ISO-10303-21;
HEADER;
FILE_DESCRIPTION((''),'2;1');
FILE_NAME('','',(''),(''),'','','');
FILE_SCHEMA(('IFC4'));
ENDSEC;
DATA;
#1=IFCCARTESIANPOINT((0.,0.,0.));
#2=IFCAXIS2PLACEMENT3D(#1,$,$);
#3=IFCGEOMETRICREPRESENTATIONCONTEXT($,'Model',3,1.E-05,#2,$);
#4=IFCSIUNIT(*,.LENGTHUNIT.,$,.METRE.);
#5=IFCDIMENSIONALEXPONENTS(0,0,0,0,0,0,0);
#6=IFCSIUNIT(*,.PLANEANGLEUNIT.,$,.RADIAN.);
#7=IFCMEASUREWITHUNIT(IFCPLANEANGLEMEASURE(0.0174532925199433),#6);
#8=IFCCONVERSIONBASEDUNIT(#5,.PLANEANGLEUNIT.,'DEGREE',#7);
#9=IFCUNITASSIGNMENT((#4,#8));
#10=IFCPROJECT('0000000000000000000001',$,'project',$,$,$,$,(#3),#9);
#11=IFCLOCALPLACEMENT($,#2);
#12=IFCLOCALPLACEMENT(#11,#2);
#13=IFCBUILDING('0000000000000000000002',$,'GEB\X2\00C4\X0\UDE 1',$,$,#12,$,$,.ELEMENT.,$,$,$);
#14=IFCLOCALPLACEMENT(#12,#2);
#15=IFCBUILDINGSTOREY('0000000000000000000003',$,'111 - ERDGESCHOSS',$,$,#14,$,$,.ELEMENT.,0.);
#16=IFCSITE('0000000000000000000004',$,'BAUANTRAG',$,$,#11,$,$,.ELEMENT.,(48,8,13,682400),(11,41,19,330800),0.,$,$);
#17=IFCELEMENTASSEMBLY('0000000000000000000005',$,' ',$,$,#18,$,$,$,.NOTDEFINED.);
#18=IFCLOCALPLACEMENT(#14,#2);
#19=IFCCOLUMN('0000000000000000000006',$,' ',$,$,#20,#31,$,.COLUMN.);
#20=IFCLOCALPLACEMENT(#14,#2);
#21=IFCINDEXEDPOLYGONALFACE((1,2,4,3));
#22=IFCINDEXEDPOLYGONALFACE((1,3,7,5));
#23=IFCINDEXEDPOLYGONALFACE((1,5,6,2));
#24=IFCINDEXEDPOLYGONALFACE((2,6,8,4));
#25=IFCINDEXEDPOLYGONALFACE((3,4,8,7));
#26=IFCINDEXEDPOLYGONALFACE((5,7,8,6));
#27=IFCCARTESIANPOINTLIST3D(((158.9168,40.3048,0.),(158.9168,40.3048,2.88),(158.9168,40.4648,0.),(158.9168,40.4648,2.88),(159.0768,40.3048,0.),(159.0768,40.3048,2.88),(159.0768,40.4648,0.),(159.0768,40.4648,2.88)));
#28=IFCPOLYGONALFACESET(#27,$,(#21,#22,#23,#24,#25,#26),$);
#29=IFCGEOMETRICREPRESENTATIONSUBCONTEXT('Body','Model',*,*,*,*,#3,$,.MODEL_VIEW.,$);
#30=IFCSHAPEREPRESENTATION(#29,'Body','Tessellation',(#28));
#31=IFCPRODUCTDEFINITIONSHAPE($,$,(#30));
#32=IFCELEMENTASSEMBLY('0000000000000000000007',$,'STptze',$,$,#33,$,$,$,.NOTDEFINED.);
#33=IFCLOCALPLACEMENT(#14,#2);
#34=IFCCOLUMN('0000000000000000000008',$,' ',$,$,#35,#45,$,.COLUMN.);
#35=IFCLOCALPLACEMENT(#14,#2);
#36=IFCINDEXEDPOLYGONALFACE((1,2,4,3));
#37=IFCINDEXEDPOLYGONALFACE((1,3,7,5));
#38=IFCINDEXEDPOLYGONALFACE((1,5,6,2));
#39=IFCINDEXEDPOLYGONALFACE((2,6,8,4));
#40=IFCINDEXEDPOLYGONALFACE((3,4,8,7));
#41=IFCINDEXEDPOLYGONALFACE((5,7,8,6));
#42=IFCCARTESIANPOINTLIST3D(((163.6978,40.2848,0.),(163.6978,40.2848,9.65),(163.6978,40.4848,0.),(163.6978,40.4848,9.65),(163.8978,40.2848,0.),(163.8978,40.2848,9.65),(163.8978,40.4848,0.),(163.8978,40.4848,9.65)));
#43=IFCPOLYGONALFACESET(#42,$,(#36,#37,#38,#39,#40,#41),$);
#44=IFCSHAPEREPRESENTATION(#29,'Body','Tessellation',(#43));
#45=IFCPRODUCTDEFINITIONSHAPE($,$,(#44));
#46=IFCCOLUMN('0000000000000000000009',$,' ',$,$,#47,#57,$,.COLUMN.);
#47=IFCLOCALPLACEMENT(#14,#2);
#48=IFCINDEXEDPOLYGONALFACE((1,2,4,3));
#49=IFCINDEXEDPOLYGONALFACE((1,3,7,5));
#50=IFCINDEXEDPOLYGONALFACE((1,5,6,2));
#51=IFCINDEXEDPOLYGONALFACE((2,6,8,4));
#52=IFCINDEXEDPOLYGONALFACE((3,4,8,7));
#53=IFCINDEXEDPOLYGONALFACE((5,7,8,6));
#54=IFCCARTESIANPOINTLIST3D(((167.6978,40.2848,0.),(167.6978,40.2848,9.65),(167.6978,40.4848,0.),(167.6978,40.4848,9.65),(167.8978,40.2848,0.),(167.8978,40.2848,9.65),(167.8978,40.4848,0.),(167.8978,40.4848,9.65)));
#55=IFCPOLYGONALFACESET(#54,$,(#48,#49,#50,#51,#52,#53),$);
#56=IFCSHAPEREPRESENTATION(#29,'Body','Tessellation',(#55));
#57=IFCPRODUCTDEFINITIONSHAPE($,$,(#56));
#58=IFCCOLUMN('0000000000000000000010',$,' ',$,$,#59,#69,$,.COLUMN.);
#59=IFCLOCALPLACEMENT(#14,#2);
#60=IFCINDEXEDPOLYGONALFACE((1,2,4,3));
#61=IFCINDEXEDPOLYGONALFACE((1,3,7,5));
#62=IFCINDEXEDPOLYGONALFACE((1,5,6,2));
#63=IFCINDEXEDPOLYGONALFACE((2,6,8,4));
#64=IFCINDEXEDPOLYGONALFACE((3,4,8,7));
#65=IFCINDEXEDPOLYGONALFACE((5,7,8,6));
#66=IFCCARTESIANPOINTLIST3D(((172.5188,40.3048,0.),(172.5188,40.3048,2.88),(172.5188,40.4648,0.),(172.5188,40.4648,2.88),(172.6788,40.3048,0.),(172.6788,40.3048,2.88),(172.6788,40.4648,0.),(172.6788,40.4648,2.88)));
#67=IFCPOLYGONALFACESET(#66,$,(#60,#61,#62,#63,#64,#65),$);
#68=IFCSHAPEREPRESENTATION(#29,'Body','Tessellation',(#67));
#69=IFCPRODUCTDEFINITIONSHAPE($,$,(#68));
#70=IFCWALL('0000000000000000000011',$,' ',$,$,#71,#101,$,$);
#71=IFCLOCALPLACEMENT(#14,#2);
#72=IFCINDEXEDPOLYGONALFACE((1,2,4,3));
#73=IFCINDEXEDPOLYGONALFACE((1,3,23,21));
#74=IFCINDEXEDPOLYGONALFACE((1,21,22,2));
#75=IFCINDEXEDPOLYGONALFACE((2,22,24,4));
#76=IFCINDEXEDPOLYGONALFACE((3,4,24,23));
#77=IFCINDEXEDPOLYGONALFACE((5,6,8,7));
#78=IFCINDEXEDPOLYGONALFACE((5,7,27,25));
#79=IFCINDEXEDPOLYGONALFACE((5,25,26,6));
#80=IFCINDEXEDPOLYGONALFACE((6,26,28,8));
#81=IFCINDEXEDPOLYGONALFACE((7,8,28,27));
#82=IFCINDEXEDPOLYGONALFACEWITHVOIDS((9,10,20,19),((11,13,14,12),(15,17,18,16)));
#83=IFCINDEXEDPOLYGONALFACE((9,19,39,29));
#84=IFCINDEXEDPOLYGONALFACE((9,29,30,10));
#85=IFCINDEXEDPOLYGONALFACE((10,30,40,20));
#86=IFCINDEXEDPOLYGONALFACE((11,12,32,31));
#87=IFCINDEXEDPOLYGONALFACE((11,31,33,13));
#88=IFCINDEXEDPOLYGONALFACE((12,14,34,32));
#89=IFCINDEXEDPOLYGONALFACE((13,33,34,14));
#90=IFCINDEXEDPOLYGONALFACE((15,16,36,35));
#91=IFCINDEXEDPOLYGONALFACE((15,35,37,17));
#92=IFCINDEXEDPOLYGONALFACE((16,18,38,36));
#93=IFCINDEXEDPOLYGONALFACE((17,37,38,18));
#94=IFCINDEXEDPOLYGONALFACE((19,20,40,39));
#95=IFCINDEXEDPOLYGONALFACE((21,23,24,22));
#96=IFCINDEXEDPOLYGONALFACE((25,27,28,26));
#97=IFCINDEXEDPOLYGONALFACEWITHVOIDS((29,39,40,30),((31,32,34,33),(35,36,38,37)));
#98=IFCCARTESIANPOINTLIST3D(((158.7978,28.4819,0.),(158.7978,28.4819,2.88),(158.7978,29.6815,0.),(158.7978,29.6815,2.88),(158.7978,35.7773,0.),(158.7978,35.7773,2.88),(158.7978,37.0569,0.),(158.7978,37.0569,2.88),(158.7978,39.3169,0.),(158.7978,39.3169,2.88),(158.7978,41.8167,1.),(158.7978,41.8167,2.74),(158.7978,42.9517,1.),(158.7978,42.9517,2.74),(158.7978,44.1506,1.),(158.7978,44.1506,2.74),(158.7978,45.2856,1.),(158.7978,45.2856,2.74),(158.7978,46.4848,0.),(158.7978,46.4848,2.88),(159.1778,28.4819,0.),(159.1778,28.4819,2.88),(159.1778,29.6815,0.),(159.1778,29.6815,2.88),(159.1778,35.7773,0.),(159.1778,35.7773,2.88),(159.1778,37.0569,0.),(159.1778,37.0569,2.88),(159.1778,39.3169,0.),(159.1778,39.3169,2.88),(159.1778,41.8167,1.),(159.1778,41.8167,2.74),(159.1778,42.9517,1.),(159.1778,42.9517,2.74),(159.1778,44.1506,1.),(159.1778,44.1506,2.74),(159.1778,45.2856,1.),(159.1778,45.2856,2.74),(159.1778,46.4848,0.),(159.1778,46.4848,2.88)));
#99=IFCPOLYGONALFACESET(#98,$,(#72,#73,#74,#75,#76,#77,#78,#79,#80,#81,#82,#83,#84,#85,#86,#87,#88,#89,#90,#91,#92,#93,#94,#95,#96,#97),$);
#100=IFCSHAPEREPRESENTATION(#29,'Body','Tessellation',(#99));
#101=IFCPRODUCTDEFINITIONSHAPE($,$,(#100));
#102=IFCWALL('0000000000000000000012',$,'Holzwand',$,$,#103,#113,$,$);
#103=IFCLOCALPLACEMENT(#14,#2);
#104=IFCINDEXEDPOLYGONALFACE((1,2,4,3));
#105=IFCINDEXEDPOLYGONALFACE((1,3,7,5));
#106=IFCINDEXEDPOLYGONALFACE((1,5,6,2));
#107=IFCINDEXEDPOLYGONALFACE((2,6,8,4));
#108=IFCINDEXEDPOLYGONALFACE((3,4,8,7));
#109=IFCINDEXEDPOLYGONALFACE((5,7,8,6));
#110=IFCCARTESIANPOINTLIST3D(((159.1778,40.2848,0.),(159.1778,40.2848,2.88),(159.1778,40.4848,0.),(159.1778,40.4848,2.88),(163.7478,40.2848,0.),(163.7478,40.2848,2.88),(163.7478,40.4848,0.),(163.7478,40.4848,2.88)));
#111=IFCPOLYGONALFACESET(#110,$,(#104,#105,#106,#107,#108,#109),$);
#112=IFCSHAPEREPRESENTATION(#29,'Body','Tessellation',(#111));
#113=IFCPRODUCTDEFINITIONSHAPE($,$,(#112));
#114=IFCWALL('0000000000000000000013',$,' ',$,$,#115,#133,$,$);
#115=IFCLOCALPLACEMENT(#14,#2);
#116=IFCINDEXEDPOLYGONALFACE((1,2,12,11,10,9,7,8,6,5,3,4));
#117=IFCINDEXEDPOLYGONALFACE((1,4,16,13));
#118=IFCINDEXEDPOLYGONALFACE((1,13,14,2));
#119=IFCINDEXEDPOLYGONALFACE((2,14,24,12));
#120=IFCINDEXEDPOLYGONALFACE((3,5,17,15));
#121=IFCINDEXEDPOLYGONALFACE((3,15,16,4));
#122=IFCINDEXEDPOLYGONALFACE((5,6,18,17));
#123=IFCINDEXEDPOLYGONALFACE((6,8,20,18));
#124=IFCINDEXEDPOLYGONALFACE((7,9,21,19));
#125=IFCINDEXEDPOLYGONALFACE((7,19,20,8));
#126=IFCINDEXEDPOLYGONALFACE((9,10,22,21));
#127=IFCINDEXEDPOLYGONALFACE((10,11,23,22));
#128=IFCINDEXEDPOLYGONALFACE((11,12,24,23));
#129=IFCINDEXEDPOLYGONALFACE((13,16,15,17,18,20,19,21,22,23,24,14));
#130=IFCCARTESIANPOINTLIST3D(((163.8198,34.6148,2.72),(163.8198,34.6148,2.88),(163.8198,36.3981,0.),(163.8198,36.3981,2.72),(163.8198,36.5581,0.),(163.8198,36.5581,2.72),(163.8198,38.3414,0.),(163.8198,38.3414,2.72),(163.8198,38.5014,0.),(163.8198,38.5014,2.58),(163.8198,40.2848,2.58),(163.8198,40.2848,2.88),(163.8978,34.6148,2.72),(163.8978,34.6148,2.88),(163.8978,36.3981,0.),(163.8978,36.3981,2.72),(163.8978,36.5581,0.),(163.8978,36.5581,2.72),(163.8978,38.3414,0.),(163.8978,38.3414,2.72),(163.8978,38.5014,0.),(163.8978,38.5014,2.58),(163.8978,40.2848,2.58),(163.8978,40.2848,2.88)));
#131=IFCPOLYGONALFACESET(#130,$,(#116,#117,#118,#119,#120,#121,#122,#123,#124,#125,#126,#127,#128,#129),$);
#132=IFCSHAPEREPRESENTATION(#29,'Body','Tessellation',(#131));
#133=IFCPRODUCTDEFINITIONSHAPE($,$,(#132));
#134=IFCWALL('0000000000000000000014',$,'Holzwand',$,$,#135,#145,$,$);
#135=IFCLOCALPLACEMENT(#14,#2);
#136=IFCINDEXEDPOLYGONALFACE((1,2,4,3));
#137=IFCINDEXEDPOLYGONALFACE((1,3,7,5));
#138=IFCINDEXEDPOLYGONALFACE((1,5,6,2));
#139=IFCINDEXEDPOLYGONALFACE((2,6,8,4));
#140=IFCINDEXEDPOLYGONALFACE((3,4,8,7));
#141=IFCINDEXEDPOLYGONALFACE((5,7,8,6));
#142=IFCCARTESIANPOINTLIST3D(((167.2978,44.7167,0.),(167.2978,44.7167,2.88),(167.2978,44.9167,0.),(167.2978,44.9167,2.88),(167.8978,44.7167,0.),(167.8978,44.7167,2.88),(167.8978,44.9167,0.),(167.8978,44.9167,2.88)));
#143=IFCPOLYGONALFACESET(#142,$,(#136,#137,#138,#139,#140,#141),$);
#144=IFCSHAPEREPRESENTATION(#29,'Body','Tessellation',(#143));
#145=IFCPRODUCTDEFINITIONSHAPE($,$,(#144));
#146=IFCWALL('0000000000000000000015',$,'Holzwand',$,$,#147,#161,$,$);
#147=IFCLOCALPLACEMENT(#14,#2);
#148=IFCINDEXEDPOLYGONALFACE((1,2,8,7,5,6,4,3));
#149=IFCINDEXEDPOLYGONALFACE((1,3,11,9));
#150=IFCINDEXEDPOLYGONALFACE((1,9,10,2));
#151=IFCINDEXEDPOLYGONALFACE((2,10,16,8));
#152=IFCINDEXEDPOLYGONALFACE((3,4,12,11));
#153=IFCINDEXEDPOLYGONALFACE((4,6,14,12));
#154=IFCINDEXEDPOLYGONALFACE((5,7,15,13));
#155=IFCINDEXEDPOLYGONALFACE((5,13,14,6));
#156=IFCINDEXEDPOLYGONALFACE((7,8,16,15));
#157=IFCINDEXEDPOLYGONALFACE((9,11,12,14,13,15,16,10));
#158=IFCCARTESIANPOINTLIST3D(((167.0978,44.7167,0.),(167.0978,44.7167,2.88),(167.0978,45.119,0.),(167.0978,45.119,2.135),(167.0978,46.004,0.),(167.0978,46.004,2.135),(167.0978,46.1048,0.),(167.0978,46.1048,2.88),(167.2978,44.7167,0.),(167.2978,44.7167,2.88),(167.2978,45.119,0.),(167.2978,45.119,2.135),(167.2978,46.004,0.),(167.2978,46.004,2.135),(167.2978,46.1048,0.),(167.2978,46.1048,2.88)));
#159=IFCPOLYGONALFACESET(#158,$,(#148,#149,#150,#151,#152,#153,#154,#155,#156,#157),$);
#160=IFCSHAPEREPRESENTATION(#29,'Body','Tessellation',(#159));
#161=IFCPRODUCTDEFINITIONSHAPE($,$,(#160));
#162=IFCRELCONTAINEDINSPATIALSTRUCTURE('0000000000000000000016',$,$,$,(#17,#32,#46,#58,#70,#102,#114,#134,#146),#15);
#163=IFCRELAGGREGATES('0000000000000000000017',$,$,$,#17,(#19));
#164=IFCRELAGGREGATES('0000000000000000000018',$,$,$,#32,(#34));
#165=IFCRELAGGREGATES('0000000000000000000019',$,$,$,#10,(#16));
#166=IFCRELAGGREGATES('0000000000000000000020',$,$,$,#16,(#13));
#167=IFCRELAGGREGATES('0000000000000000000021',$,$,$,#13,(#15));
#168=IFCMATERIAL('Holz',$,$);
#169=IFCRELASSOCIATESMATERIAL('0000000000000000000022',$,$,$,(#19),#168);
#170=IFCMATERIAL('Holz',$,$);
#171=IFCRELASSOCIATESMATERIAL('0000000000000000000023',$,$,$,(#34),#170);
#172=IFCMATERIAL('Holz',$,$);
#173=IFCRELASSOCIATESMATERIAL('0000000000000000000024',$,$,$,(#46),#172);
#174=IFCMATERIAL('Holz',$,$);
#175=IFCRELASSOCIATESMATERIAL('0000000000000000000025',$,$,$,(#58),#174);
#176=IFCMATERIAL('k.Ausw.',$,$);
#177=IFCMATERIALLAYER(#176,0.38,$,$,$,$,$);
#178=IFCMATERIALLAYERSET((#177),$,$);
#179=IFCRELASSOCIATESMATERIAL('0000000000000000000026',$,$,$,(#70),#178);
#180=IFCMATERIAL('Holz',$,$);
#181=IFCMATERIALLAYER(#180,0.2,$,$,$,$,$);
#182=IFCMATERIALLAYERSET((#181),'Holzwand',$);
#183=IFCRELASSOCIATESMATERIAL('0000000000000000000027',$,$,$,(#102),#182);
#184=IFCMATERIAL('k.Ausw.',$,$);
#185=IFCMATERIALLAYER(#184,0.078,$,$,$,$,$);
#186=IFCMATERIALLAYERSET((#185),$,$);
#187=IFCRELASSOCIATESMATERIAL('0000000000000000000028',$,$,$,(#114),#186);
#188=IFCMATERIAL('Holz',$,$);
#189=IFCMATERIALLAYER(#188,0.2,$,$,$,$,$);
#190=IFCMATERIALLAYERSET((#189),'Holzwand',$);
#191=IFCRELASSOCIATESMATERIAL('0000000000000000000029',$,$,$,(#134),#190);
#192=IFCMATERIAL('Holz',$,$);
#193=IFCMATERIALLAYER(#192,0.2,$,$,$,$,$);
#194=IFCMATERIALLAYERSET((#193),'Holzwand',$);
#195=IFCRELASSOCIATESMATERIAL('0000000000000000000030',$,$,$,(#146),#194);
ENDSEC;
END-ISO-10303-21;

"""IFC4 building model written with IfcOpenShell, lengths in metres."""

from ifc_helpers import new_model, entity, si_unit, converted_unit, frame, frame_2d, origin, origin_with_axes, place, context, subcontext, project, spatial, polyline, rectangle, outline, extrude, material, layer, layer_set, layer_usage, element, aggregate, save


model = new_model("IFC4")

# Units and contexts
model_context = context("Model", 3, precision=1e-05, world=origin())
body_context = subcontext(model_context, "Body", "Model", "MODEL_VIEW")
ifc_project = project(units=[si_unit("LENGTHUNIT", "METRE"), converted_unit("PLANEANGLEUNIT", "DEGREE", entity("IfcPlaneAngleMeasure", 0.0174532925199433), si_unit("PLANEANGLEUNIT", "RADIAN"), dimensions=[0, 0, 0, 0, 0, 0, 0])], contexts=[model_context])

# Site, building, storey
site_placement = place(None, origin())
site = spatial("IfcSite", under=ifc_project, at=site_placement, Name="BAUANTRAG", CompositionType="ELEMENT", RefLatitude=(48, 8, 13, 682400), RefLongitude=(11, 41, 19, 330800), RefElevation=0.0)
building_placement = place(site_placement, origin())
building = spatial("IfcBuilding", under=site, at=building_placement, Name="GEBÄUDE 1", CompositionType="ELEMENT")
storey_placement = place(building_placement, origin())
storey = spatial("IfcBuildingStorey", under=building, at=storey_placement, Name="111 - ERDGESCHOSS", CompositionType="ELEMENT", Elevation=0.0)

# Element assemblies, columns
assembly_1_placement = place(storey_placement, origin())
assembly_1 = element("IfcElementAssembly", 1, at=assembly_1_placement, inside=storey, Name=" ", PredefinedType="NOTDEFINED")
ifc_material_1 = material(Name="Holz")
column_1_placement = place(assembly_1_placement, frame((158.9168, 40.3048, 0.0)))
column_1 = element("IfcColumn", 2, at=column_1_placement, material=ifc_material_1, Name=" ", PredefinedType="COLUMN", context=body_context, shape_type="SweptSolid", body=[
    extrude(rectangle(XDim=0.16, YDim=0.16, at=frame_2d((0.08, 0.08), x_axis=(1.0, 0.0))), origin_with_axes(), (0.0, 0.0, 1.0), 2.88),
])
aggregate(assembly_1, [column_1])
assembly_2_placement = place(storey_placement, origin())
assembly_2 = element("IfcElementAssembly", 3, at=assembly_2_placement, inside=storey, Name="STptze", PredefinedType="NOTDEFINED")
ifc_material_2 = material(Name="Holz")
column_2_placement = place(assembly_2_placement, frame((163.6978, 40.2848, 0.0)))
column_2 = element("IfcColumn", 4, at=column_2_placement, material=ifc_material_2, Name=" ", PredefinedType="COLUMN", context=body_context, shape_type="SweptSolid", body=[
    extrude(rectangle(XDim=0.2, YDim=0.2, at=frame_2d((0.1, 0.1), x_axis=(1.0, 0.0))), origin_with_axes(), (0.0, 0.0, 1.0), 9.65),
])
aggregate(assembly_2, [column_2])

# Columns
ifc_material_3 = material(Name="Holz")
column_3_placement = place(storey_placement, frame((167.6978, 40.2848, 0.0)))
element("IfcColumn", 5, at=column_3_placement, inside=storey, material=ifc_material_3, Name=" ", PredefinedType="COLUMN", context=body_context, shape_type="SweptSolid", body=[
    extrude(rectangle(XDim=0.2, YDim=0.2, at=frame_2d((0.1, 0.1), x_axis=(1.0, 0.0))), origin_with_axes(), (0.0, 0.0, 1.0), 9.65),
])
ifc_material_4 = material(Name="Holz")
column_4_placement = place(storey_placement, frame((172.5188, 40.3048, 0.0)))
element("IfcColumn", 6, at=column_4_placement, inside=storey, material=ifc_material_4, Name=" ", PredefinedType="COLUMN", context=body_context, shape_type="SweptSolid", body=[
    extrude(rectangle(XDim=0.16, YDim=0.16, at=frame_2d((0.08, 0.08), x_axis=(1.0, 0.0))), origin_with_axes(), (0.0, 0.0, 1.0), 2.88),
])

# Wall, openings
ifc_material_5 = material(Name="k.Ausw.")
ifc_layer_1 = layer(ifc_material_5, 0.38)
ifc_layer_set_1 = layer_set([ifc_layer_1])
ifc_layer_usage_1 = layer_usage(ifc_layer_set_1, "AXIS2", "POSITIVE", 0.0)
wall_1_placement = place(storey_placement, frame((158.7978, 46.4848, 0.0), z_axis=(0.0, 0.0, 1.0), x_axis=(0.0, -1.0, 0.0)))
wall_1 = element("IfcWall", 7, at=wall_1_placement, inside=storey, material=ifc_layer_usage_1, Name=" ", context=body_context, shape_type="SweptSolid", body=[
    extrude(rectangle(XDim=18.0029, YDim=0.38, at=frame_2d((9.0014, 0.19), x_axis=(1.0, 0.0))), origin_with_axes(), (0.0, 0.0, 1.0), 2.88),
])
opening_1_placement = place(wall_1_placement, frame((12.0614, 0.0, 0.0), z_axis=(0.0, 1.0, 0.0), x_axis=(0.0, 0.0, 1.0)))
element("IfcOpeningElement", 8, at=opening_1_placement, cuts=wall_1, ObjectType="Opening", context=body_context, shape_type="SweptSolid", body=[
    extrude(outline(polyline([(0.0, 3.608), (2.88, 3.608), (2.88, 0.0), (0.0, 0.0), (0.0, 3.608)])), origin_with_axes(), (0.0, 0.0, 1.0), 0.38),
])
opening_2_placement = place(wall_1_placement, frame((10.7075, 0.0, 0.0), z_axis=(0.0, 1.0, 0.0), x_axis=(0.0, 0.0, 1.0)))
element("IfcOpeningElement", 9, at=opening_2_placement, cuts=wall_1, ObjectType="Opening", context=body_context, shape_type="SweptSolid", body=[
    extrude(outline(polyline([(0.0, 1.3539), (2.88, 1.3539), (2.88, 0.0), (0.0, 0.0), (0.0, 1.3539)])), origin_with_axes(), (0.0, 0.0, 1.0), 0.38),
])
opening_3_placement = place(wall_1_placement, frame((7.1679, 0.0, 0.0), z_axis=(0.0, 1.0, 0.0), x_axis=(0.0, 0.0, 1.0)))
element("IfcOpeningElement", 10, at=opening_3_placement, cuts=wall_1, ObjectType="Opening", context=body_context, shape_type="SweptSolid", body=[
    extrude(outline(polyline([(0.0, 2.26), (2.88, 2.26), (2.88, 0.0), (0.0, 0.0), (0.0, 2.26)])), origin_with_axes(), (0.0, 0.0, 1.0), 0.38),
])
opening_4_placement = place(wall_1_placement, frame((1.1992, 0.0, 1.0), z_axis=(0.0, 1.0, 0.0), x_axis=(0.0, 0.0, 1.0)))
element("IfcOpeningElement", 11, at=opening_4_placement, cuts=wall_1, ObjectType="Opening", context=body_context, shape_type="SweptSolid", body=[
    extrude(outline(polyline([(0.0, 1.135), (1.74, 1.135), (1.74, 0.0), (0.0, 0.0), (0.0, 1.135)])), origin_with_axes(), (0.0, 0.0, 1.0), 0.38),
])
opening_5_placement = place(wall_1_placement, frame((3.5331, 0.0, 1.0), z_axis=(0.0, 1.0, 0.0), x_axis=(0.0, 0.0, 1.0)))
element("IfcOpeningElement", 12, at=opening_5_placement, cuts=wall_1, ObjectType="Opening", context=body_context, shape_type="SweptSolid", body=[
    extrude(outline(polyline([(0.0, 1.135), (1.74, 1.135), (1.74, 0.0), (0.0, 0.0), (0.0, 1.135)])), origin_with_axes(), (0.0, 0.0, 1.0), 0.38),
])
opening_6_placement = place(wall_1_placement, frame((15.6683, 0.0, 0.0), z_axis=(0.0, 1.0, 0.0), x_axis=(0.0, 0.0, 1.0)))
element("IfcOpeningElement", 13, at=opening_6_placement, cuts=wall_1, ObjectType="Opening", context=body_context, shape_type="SweptSolid", body=[
    extrude(outline(polyline([(0.0, 1.135), (2.88, 1.135), (2.88, 0.0), (0.0, 0.0), (0.0, 1.135)])), origin_with_axes(), (0.0, 0.0, 1.0), 0.38),
])

# Wall
ifc_material_6 = material(Name="Holz")
ifc_layer_2 = layer(ifc_material_6, 0.2)
ifc_layer_set_2 = layer_set([ifc_layer_2], Name="Holzwand")
ifc_layer_usage_2 = layer_usage(ifc_layer_set_2, "AXIS2", "POSITIVE", 0.0)
wall_2_placement = place(storey_placement, frame((163.7478, 40.4848, 0.0), z_axis=(0.0, 0.0, 1.0), x_axis=(-1.0, 0.0, 0.0)))
element("IfcWall", 14, at=wall_2_placement, inside=storey, material=ifc_layer_usage_2, Name="Holzwand", context=body_context, shape_type="SweptSolid", body=[
    extrude(rectangle(XDim=4.57, YDim=0.2, at=frame_2d((2.285, 0.1), x_axis=(1.0, 0.0))), origin_with_axes(), (0.0, 0.0, 1.0), 2.88),
])

# Wall, openings
ifc_material_7 = material(Name="k.Ausw.")
ifc_layer_3 = layer(ifc_material_7, 0.078)
ifc_layer_set_3 = layer_set([ifc_layer_3])
ifc_layer_usage_3 = layer_usage(ifc_layer_set_3, "AXIS2", "POSITIVE", 0.0)
wall_3_placement = place(storey_placement, frame((163.8198, 40.2848, 0.0), z_axis=(0.0, 0.0, 1.0), x_axis=(0.0, -1.0, 0.0)))
wall_3 = element("IfcWall", 15, at=wall_3_placement, inside=storey, material=ifc_layer_usage_3, Name=" ", context=body_context, shape_type="SweptSolid", body=[
    extrude(rectangle(XDim=5.67, YDim=0.078, at=frame_2d((2.835, 0.039), x_axis=(1.0, 0.0))), origin_with_axes(), (0.0, 0.0, 1.0), 2.88),
])
opening_7_placement = place(wall_3_placement, frame((1.9434, 0.0, 0.0), z_axis=(0.0, 1.0, 0.0), x_axis=(0.0, 0.0, 1.0)))
element("IfcOpeningElement", 16, at=opening_7_placement, cuts=wall_3, ObjectType="Opening", context=body_context, shape_type="SweptSolid", body=[
    extrude(outline(polyline([(0.0, 1.7833), (2.72, 1.7833), (2.72, 0.0), (0.0, 0.0), (0.0, 1.7833)])), origin_with_axes(), (0.0, 0.0, 1.0), 0.078),
])
opening_8_placement = place(wall_3_placement, frame((3.8867, 0.0, 0.0), z_axis=(0.0, 1.0, 0.0), x_axis=(0.0, 0.0, 1.0)))
element("IfcOpeningElement", 17, at=opening_8_placement, cuts=wall_3, ObjectType="Opening", context=body_context, shape_type="SweptSolid", body=[
    extrude(outline(polyline([(0.0, 1.7833), (2.72, 1.7833), (2.72, 0.0), (0.0, 0.0), (0.0, 1.7833)])), origin_with_axes(), (0.0, 0.0, 1.0), 0.078),
])
opening_9_placement = place(wall_3_placement, frame((0.0, 0.0, -0.14), z_axis=(0.0, 1.0, 0.0), x_axis=(0.0, 0.0, 1.0)))
element("IfcOpeningElement", 18, at=opening_9_placement, cuts=wall_3, ObjectType="Opening", context=body_context, shape_type="SweptSolid", body=[
    extrude(outline(polyline([(0.0, 1.7834), (2.72, 1.7834), (2.72, 0.0), (0.0, 0.0), (0.0, 1.7834)])), origin_with_axes(), (0.0, 0.0, 1.0), 0.078),
])

# Wall
ifc_material_8 = material(Name="Holz")
ifc_layer_4 = layer(ifc_material_8, 0.2)
ifc_layer_set_4 = layer_set([ifc_layer_4], Name="Holzwand")
ifc_layer_usage_4 = layer_usage(ifc_layer_set_4, "AXIS2", "POSITIVE", 0.0)
wall_4_placement = place(storey_placement, frame((167.2978, 44.7167, 0.0)))
element("IfcWall", 19, at=wall_4_placement, inside=storey, material=ifc_layer_usage_4, Name="Holzwand", context=body_context, shape_type="SweptSolid", body=[
    extrude(rectangle(XDim=0.6, YDim=0.2, at=frame_2d((0.3, 0.1), x_axis=(1.0, 0.0))), origin_with_axes(), (0.0, 0.0, 1.0), 2.88),
])

# Wall, opening
ifc_material_9 = material(Name="Holz")
ifc_layer_5 = layer(ifc_material_9, 0.2)
ifc_layer_set_5 = layer_set([ifc_layer_5], Name="Holzwand")
ifc_layer_usage_5 = layer_usage(ifc_layer_set_5, "AXIS2", "POSITIVE", 0.0)
wall_5_placement = place(storey_placement, frame((167.0978, 46.1048, 0.0), z_axis=(0.0, 0.0, 1.0), x_axis=(0.0, -1.0, 0.0)))
wall_5 = element("IfcWall", 20, at=wall_5_placement, inside=storey, material=ifc_layer_usage_5, Name="Holzwand", context=body_context, shape_type="SweptSolid", body=[
    extrude(rectangle(XDim=1.3881, YDim=0.2, at=frame_2d((0.6941, 0.1), x_axis=(1.0, 0.0))), origin_with_axes(), (0.0, 0.0, 1.0), 2.88),
])
opening_10_placement = place(wall_5_placement, frame((0.9858, 0.2, 0.0), z_axis=(0.0, -1.0, 0.0), x_axis=(0.0, 0.0, 1.0)))
element("IfcOpeningElement", 21, at=opening_10_placement, cuts=wall_5, ObjectType="Opening", context=body_context, shape_type="SweptSolid", body=[
    extrude(outline(polyline([(0.0, 0.885), (2.135, 0.885), (2.135, 0.0), (0.0, 0.0), (0.0, 0.885)])), origin_with_axes(), (0.0, 0.0, 1.0), 0.2),
])

save(model, "model.ifc")
